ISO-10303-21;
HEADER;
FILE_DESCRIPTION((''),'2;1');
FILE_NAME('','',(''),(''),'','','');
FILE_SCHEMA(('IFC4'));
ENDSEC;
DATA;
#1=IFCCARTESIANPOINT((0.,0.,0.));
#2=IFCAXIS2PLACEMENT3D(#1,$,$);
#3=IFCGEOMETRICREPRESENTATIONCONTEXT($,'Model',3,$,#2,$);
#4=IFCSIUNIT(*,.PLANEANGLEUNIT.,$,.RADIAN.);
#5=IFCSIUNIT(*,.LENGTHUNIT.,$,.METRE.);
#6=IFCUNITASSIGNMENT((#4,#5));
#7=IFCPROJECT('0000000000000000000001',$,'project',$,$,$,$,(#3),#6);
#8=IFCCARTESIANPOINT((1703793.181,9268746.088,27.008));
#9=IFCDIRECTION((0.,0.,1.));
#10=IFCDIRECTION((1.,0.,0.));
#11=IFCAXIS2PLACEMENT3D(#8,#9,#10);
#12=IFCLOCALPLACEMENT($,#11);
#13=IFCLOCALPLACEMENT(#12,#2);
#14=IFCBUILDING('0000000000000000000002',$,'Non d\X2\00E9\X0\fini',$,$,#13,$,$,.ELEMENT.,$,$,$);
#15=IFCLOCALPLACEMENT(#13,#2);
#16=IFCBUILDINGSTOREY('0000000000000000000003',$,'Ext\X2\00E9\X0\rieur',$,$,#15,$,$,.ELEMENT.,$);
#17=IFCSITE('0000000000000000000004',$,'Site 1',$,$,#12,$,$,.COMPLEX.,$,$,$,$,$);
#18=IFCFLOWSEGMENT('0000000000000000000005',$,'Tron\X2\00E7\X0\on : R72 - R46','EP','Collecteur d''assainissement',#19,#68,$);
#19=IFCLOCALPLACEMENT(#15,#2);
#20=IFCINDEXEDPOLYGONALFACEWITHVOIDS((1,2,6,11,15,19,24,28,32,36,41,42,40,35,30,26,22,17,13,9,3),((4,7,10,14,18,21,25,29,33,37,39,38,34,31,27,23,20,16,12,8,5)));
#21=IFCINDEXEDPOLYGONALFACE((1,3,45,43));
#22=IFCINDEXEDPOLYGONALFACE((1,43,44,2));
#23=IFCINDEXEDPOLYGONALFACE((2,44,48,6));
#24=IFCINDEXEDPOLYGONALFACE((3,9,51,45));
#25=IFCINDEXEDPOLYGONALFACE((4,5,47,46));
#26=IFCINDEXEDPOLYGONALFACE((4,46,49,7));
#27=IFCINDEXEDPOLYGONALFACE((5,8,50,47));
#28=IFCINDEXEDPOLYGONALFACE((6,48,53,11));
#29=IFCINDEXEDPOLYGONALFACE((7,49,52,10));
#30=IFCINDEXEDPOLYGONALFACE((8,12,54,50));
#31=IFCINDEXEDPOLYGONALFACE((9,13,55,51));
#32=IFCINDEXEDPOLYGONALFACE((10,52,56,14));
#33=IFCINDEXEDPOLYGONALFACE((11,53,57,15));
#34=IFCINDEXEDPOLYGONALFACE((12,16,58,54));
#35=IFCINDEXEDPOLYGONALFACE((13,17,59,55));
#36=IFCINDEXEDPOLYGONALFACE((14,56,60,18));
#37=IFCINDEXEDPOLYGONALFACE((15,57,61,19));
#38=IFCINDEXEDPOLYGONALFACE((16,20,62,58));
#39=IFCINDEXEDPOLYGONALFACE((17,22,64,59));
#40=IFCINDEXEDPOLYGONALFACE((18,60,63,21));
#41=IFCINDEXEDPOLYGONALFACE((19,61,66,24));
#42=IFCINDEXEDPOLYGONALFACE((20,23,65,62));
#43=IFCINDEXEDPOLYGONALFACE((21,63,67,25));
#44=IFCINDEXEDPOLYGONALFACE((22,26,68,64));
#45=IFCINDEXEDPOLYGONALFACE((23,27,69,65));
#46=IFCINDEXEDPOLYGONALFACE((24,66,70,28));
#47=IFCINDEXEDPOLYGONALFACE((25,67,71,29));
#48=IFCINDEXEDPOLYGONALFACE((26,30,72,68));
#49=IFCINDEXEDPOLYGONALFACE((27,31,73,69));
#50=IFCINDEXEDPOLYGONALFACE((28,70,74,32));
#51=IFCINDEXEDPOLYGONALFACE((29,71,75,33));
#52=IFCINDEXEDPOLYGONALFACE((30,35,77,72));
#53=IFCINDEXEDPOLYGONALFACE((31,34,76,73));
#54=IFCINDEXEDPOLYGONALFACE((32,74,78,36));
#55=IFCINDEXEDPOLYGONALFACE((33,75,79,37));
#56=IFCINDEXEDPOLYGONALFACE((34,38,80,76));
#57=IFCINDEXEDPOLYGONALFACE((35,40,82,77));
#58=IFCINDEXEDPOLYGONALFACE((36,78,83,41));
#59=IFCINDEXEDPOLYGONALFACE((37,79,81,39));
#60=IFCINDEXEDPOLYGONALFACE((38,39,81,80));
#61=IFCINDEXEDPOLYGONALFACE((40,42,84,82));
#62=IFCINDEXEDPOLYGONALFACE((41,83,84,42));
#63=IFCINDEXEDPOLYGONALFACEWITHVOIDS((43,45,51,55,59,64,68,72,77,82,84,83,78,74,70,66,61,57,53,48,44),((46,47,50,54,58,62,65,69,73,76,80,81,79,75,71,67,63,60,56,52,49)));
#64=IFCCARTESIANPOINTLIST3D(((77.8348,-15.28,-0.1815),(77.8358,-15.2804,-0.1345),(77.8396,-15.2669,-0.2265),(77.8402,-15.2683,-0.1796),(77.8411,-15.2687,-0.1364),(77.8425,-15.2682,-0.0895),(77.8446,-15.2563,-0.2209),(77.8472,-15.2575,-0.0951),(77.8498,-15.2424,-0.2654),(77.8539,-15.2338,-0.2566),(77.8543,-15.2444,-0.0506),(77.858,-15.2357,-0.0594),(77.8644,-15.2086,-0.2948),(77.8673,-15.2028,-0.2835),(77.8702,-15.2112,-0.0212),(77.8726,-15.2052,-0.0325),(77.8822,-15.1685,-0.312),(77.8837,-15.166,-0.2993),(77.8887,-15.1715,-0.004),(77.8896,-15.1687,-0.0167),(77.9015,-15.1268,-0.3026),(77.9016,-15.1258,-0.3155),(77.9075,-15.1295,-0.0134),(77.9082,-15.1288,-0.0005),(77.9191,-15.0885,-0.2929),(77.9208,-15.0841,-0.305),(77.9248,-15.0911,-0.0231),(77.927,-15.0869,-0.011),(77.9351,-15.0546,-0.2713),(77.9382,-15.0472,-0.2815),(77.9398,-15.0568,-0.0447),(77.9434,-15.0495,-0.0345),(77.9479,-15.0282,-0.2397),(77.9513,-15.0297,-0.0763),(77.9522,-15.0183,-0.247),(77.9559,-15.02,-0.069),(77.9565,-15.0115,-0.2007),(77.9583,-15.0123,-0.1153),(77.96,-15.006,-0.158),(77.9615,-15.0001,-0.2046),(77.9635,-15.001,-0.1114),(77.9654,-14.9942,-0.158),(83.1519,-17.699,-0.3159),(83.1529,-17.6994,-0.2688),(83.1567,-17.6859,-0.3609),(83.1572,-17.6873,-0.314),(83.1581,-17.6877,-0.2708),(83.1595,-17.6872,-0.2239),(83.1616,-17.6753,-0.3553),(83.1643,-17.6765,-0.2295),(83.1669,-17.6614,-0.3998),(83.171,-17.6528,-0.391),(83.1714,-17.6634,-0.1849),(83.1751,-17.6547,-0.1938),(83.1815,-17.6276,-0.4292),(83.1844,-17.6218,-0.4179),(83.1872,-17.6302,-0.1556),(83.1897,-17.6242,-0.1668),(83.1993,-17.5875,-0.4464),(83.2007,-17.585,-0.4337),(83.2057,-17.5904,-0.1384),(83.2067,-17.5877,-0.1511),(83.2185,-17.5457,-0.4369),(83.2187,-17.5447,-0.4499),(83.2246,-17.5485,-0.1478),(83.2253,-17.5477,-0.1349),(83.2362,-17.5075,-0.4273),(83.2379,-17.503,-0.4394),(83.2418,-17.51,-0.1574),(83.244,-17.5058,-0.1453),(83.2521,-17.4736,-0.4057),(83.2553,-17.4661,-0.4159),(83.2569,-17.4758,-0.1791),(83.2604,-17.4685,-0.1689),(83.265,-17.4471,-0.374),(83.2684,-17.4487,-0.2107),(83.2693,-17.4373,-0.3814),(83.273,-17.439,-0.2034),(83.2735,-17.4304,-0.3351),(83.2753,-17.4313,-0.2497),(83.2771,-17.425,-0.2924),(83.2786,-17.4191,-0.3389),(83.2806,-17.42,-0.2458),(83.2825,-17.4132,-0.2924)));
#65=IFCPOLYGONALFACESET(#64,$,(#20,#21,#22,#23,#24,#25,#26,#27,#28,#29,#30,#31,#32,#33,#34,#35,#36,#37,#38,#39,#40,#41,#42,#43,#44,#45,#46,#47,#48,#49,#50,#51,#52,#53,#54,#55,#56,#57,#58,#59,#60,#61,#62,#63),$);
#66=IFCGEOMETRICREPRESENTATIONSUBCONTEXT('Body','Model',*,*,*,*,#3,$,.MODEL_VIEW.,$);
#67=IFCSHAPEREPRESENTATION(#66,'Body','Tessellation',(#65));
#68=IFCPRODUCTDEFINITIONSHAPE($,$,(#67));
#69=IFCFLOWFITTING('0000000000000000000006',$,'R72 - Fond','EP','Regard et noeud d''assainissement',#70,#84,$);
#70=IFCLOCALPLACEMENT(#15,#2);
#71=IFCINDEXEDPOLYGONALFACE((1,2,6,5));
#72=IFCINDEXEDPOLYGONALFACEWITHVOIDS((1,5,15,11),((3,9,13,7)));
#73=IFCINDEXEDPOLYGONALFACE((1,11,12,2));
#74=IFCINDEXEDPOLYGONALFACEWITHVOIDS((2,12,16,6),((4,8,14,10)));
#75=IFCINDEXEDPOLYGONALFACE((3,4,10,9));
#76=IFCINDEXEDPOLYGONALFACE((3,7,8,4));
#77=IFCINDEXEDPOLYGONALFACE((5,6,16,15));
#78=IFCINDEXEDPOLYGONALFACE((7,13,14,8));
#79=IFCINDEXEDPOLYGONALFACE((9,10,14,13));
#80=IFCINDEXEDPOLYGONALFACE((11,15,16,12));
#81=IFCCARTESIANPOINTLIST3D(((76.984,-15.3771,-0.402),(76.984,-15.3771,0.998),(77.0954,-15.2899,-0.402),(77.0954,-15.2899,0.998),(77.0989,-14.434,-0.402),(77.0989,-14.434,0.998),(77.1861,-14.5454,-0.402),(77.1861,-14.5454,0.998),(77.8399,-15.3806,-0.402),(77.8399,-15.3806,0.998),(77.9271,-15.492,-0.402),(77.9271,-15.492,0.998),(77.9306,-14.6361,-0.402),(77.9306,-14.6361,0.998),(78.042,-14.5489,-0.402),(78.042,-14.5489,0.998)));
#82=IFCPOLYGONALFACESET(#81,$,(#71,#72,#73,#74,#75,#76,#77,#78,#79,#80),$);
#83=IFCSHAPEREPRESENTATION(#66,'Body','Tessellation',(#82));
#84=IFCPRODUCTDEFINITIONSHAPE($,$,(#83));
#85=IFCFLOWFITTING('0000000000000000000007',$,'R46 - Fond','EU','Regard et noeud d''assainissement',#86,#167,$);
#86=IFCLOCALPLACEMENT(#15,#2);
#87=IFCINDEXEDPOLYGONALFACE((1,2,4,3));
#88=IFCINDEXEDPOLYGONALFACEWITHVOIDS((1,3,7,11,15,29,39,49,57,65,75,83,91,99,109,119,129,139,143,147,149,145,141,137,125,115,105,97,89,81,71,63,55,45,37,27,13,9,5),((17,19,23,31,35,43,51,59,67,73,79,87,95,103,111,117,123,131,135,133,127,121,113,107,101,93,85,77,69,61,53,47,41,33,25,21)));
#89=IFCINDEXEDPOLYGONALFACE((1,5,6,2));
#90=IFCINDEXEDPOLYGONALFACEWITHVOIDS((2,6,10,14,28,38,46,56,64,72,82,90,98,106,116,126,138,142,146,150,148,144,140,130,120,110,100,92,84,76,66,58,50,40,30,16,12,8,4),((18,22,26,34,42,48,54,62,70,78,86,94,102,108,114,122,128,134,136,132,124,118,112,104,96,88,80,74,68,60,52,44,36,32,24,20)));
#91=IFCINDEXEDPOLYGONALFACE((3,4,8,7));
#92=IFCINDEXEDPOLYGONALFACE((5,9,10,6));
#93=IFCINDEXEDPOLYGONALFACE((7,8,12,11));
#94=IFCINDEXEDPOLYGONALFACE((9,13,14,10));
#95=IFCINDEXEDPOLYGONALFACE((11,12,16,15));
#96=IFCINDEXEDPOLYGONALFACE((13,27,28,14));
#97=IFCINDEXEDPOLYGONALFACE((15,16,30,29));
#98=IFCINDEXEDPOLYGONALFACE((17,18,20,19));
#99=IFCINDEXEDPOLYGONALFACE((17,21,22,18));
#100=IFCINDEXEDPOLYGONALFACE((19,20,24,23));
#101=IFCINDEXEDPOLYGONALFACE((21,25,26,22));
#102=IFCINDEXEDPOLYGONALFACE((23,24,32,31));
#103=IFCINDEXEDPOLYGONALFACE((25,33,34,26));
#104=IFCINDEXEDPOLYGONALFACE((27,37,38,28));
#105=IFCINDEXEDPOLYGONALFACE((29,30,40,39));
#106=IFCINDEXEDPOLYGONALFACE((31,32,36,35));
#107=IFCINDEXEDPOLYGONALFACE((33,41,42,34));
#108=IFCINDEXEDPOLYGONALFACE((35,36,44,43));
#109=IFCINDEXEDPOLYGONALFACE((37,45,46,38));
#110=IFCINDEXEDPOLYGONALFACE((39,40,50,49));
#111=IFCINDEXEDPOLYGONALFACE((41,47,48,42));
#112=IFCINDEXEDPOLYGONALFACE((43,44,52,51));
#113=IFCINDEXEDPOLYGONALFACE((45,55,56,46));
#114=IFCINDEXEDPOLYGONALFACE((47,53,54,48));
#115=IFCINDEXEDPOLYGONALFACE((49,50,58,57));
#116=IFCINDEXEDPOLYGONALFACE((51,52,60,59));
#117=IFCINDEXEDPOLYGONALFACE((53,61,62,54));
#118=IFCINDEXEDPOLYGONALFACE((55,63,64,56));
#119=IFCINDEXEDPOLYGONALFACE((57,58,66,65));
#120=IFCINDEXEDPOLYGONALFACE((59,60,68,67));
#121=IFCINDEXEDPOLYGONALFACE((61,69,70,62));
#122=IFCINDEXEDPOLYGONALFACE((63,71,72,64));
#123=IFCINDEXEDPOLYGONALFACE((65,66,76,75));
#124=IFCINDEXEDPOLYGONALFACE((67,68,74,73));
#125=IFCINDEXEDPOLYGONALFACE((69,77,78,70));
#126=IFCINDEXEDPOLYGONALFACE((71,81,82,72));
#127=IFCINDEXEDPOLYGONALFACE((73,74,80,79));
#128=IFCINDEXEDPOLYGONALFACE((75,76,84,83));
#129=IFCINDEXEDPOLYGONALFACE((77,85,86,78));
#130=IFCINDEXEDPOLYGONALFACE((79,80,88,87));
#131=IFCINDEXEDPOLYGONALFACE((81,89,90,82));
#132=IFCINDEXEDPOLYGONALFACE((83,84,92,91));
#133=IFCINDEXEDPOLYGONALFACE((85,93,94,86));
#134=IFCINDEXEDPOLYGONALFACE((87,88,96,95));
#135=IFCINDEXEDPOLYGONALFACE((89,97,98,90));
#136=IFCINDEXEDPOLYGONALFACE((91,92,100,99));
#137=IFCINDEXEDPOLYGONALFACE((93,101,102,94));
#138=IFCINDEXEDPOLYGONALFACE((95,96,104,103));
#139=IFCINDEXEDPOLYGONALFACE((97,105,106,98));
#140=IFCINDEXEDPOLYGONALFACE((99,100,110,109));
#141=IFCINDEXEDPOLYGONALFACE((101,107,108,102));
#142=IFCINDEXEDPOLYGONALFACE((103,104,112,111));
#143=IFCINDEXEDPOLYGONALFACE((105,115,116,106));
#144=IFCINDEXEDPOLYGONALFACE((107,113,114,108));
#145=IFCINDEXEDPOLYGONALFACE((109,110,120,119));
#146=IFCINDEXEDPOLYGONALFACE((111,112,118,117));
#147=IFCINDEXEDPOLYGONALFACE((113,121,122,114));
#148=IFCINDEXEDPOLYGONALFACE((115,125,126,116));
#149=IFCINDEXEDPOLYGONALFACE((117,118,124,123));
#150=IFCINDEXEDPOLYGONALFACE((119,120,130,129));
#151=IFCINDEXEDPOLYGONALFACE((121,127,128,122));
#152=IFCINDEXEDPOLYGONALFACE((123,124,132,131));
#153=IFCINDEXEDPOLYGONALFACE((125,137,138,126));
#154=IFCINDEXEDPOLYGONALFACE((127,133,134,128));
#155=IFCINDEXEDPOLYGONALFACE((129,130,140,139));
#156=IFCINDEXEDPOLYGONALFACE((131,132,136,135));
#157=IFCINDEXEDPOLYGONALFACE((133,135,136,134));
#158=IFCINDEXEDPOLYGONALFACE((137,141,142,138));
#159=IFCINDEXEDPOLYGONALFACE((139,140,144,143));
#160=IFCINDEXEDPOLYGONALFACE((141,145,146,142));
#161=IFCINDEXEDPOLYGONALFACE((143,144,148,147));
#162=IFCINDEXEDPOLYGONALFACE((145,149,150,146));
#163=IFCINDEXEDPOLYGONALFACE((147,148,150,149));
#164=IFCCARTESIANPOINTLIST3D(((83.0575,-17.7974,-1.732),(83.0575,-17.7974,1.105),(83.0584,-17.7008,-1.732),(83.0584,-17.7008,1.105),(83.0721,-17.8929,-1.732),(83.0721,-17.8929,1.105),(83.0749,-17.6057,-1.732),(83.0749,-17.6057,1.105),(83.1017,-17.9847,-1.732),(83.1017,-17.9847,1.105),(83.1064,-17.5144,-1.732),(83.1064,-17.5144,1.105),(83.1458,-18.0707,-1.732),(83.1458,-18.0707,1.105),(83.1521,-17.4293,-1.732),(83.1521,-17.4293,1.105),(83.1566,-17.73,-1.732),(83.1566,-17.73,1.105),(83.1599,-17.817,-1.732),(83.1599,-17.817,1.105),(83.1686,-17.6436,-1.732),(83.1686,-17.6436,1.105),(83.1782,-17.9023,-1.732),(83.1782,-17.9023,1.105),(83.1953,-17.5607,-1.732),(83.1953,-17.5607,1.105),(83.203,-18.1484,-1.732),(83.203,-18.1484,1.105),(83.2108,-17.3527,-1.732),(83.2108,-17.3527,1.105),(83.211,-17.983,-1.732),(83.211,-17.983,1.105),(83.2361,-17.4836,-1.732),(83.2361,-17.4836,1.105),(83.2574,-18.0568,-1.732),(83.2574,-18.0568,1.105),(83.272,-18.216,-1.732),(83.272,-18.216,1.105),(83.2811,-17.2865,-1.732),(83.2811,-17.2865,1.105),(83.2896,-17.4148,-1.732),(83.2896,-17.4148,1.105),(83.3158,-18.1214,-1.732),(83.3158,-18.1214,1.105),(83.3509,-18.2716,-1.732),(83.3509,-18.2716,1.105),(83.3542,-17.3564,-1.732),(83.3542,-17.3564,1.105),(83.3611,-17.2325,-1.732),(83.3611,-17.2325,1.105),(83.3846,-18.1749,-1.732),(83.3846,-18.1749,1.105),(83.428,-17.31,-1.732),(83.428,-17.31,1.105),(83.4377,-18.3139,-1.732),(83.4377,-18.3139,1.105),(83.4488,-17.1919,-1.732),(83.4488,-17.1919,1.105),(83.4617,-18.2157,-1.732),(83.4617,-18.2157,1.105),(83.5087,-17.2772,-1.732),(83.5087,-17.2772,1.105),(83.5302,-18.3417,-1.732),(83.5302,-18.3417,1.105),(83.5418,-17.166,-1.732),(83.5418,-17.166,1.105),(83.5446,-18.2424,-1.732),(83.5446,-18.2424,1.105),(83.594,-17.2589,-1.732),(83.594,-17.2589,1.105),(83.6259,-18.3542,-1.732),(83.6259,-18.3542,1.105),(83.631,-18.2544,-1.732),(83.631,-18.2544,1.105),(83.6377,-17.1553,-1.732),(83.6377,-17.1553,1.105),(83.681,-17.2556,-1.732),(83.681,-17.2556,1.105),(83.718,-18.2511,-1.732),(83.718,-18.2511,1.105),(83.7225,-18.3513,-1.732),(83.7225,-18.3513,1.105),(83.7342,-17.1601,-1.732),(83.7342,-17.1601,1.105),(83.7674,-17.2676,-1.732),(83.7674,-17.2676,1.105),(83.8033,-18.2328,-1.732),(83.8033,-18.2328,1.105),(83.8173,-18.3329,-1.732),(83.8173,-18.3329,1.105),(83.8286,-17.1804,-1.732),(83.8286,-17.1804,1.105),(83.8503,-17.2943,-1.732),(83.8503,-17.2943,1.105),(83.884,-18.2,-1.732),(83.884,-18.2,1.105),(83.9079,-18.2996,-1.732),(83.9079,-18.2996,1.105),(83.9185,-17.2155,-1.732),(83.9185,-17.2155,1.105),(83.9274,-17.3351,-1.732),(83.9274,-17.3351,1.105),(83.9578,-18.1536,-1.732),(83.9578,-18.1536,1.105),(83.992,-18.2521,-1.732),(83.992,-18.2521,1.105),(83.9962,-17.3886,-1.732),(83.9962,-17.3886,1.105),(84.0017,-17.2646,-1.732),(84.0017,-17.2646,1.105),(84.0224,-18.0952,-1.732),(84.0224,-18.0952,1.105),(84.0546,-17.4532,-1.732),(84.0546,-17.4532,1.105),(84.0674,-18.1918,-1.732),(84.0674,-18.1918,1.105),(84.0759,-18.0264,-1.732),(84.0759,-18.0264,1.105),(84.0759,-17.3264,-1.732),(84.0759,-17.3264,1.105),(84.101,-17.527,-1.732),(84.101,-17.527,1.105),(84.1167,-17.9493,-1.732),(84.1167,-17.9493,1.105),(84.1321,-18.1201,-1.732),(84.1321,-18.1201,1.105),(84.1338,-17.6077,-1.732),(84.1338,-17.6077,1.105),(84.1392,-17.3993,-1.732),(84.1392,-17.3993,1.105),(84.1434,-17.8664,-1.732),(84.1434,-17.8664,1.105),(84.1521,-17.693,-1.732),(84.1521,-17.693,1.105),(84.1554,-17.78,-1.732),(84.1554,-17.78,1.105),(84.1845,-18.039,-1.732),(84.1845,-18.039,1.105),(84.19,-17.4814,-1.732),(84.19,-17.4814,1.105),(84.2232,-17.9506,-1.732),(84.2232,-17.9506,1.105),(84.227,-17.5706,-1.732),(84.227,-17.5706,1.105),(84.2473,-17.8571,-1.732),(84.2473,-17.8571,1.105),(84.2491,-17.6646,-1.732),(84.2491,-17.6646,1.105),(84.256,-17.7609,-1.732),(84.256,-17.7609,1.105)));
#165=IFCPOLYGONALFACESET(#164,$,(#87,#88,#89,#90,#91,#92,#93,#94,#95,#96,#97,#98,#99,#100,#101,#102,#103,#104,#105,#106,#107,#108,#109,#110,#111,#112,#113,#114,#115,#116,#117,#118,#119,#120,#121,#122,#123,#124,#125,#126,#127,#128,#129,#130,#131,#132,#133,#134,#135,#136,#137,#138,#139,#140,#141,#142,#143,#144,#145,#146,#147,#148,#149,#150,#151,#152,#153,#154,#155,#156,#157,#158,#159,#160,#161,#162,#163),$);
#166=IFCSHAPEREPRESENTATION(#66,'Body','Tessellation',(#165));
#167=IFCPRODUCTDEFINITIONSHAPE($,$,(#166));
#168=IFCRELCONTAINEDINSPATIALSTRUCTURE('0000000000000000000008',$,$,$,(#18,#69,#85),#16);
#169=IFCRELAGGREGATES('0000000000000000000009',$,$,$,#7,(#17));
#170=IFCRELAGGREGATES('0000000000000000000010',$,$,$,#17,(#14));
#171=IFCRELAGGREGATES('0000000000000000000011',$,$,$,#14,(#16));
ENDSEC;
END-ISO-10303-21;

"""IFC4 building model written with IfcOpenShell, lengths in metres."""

from ifc_helpers import new_model, si_unit, frame, origin, origin_2d, place, context, subcontext, project, spatial, hollow_rectangle, hollow_circle, extrude, element, save


model = new_model("IFC4")

# Units and contexts
model_context = context("Model", 3, world=origin())
body_context = subcontext(model_context, "Body", "Model", "MODEL_VIEW")
ifc_project = project(units=[si_unit("PLANEANGLEUNIT", "RADIAN"), si_unit("LENGTHUNIT", "METRE")], contexts=[model_context])

# Site, building, storey
site_placement = place(None, frame((1703793.181, 9268746.088, 27.008), z_axis=(0.0, 0.0, 1.0), x_axis=(1.0, 0.0, 0.0)))
site = spatial("IfcSite", under=ifc_project, at=site_placement, Name="Site 1", CompositionType="COMPLEX")
building_placement = place(site_placement, origin())
building = spatial("IfcBuilding", under=site, at=building_placement, Name="Non défini", CompositionType="ELEMENT")
storey_placement = place(building_placement, origin())
storey = spatial("IfcBuildingStorey", under=building, at=storey_placement, Name="Extérieur", CompositionType="ELEMENT")

# Flow segment
flow_segment_1_placement = place(storey_placement, origin())
element("IfcFlowSegment", 1, at=flow_segment_1_placement, inside=storey, Name="Tronçon : R72 - R46", Description="EP", ObjectType="Collecteur d'assainissement", context=body_context, shape_type="SweptSolid", body=[
    extrude(hollow_circle(Radius=0.158, WallThickness=0.013, at=origin_2d()), frame((77.9, -15.138, -0.158), z_axis=(0.91, -0.414, -0.023), x_axis=(0.414, 0.91, 0.0)), (0.0, 0.0, 1.0), 5.843),
])

# Flow fittings
flow_fitting_1_placement = place(storey_placement, origin())
element("IfcFlowFitting", 2, at=flow_fitting_1_placement, inside=storey, Name="R72 - Fond", Description="EP", ObjectType="Regard et noeud d'assainissement", context=body_context, shape_type="SweptSolid", body=[
    extrude(hollow_rectangle(XDim=0.95, YDim=0.95, WallThickness=0.1, at=origin_2d()), frame((77.513, -14.963, -0.402), z_axis=(0.0, 0.0, 1.0), x_axis=(0.121, 0.993, 0.0)), (0.0, 0.0, 1.0), 1.4),
])
flow_fitting_2_placement = place(storey_placement, origin())
element("IfcFlowFitting", 3, at=flow_fitting_2_placement, inside=storey, Name="R46 - Fond", Description="EU", ObjectType="Regard et noeud d'assainissement", context=body_context, shape_type="SweptSolid", body=[
    extrude(hollow_circle(Radius=0.6, WallThickness=0.1, at=origin_2d()), frame((83.656, -17.755, -1.732), z_axis=(0.0, 0.0, 1.0), x_axis=(0.89, 0.456, 0.0)), (0.0, 0.0, 1.0), 2.837),
])

save(model, "model.ifc")
